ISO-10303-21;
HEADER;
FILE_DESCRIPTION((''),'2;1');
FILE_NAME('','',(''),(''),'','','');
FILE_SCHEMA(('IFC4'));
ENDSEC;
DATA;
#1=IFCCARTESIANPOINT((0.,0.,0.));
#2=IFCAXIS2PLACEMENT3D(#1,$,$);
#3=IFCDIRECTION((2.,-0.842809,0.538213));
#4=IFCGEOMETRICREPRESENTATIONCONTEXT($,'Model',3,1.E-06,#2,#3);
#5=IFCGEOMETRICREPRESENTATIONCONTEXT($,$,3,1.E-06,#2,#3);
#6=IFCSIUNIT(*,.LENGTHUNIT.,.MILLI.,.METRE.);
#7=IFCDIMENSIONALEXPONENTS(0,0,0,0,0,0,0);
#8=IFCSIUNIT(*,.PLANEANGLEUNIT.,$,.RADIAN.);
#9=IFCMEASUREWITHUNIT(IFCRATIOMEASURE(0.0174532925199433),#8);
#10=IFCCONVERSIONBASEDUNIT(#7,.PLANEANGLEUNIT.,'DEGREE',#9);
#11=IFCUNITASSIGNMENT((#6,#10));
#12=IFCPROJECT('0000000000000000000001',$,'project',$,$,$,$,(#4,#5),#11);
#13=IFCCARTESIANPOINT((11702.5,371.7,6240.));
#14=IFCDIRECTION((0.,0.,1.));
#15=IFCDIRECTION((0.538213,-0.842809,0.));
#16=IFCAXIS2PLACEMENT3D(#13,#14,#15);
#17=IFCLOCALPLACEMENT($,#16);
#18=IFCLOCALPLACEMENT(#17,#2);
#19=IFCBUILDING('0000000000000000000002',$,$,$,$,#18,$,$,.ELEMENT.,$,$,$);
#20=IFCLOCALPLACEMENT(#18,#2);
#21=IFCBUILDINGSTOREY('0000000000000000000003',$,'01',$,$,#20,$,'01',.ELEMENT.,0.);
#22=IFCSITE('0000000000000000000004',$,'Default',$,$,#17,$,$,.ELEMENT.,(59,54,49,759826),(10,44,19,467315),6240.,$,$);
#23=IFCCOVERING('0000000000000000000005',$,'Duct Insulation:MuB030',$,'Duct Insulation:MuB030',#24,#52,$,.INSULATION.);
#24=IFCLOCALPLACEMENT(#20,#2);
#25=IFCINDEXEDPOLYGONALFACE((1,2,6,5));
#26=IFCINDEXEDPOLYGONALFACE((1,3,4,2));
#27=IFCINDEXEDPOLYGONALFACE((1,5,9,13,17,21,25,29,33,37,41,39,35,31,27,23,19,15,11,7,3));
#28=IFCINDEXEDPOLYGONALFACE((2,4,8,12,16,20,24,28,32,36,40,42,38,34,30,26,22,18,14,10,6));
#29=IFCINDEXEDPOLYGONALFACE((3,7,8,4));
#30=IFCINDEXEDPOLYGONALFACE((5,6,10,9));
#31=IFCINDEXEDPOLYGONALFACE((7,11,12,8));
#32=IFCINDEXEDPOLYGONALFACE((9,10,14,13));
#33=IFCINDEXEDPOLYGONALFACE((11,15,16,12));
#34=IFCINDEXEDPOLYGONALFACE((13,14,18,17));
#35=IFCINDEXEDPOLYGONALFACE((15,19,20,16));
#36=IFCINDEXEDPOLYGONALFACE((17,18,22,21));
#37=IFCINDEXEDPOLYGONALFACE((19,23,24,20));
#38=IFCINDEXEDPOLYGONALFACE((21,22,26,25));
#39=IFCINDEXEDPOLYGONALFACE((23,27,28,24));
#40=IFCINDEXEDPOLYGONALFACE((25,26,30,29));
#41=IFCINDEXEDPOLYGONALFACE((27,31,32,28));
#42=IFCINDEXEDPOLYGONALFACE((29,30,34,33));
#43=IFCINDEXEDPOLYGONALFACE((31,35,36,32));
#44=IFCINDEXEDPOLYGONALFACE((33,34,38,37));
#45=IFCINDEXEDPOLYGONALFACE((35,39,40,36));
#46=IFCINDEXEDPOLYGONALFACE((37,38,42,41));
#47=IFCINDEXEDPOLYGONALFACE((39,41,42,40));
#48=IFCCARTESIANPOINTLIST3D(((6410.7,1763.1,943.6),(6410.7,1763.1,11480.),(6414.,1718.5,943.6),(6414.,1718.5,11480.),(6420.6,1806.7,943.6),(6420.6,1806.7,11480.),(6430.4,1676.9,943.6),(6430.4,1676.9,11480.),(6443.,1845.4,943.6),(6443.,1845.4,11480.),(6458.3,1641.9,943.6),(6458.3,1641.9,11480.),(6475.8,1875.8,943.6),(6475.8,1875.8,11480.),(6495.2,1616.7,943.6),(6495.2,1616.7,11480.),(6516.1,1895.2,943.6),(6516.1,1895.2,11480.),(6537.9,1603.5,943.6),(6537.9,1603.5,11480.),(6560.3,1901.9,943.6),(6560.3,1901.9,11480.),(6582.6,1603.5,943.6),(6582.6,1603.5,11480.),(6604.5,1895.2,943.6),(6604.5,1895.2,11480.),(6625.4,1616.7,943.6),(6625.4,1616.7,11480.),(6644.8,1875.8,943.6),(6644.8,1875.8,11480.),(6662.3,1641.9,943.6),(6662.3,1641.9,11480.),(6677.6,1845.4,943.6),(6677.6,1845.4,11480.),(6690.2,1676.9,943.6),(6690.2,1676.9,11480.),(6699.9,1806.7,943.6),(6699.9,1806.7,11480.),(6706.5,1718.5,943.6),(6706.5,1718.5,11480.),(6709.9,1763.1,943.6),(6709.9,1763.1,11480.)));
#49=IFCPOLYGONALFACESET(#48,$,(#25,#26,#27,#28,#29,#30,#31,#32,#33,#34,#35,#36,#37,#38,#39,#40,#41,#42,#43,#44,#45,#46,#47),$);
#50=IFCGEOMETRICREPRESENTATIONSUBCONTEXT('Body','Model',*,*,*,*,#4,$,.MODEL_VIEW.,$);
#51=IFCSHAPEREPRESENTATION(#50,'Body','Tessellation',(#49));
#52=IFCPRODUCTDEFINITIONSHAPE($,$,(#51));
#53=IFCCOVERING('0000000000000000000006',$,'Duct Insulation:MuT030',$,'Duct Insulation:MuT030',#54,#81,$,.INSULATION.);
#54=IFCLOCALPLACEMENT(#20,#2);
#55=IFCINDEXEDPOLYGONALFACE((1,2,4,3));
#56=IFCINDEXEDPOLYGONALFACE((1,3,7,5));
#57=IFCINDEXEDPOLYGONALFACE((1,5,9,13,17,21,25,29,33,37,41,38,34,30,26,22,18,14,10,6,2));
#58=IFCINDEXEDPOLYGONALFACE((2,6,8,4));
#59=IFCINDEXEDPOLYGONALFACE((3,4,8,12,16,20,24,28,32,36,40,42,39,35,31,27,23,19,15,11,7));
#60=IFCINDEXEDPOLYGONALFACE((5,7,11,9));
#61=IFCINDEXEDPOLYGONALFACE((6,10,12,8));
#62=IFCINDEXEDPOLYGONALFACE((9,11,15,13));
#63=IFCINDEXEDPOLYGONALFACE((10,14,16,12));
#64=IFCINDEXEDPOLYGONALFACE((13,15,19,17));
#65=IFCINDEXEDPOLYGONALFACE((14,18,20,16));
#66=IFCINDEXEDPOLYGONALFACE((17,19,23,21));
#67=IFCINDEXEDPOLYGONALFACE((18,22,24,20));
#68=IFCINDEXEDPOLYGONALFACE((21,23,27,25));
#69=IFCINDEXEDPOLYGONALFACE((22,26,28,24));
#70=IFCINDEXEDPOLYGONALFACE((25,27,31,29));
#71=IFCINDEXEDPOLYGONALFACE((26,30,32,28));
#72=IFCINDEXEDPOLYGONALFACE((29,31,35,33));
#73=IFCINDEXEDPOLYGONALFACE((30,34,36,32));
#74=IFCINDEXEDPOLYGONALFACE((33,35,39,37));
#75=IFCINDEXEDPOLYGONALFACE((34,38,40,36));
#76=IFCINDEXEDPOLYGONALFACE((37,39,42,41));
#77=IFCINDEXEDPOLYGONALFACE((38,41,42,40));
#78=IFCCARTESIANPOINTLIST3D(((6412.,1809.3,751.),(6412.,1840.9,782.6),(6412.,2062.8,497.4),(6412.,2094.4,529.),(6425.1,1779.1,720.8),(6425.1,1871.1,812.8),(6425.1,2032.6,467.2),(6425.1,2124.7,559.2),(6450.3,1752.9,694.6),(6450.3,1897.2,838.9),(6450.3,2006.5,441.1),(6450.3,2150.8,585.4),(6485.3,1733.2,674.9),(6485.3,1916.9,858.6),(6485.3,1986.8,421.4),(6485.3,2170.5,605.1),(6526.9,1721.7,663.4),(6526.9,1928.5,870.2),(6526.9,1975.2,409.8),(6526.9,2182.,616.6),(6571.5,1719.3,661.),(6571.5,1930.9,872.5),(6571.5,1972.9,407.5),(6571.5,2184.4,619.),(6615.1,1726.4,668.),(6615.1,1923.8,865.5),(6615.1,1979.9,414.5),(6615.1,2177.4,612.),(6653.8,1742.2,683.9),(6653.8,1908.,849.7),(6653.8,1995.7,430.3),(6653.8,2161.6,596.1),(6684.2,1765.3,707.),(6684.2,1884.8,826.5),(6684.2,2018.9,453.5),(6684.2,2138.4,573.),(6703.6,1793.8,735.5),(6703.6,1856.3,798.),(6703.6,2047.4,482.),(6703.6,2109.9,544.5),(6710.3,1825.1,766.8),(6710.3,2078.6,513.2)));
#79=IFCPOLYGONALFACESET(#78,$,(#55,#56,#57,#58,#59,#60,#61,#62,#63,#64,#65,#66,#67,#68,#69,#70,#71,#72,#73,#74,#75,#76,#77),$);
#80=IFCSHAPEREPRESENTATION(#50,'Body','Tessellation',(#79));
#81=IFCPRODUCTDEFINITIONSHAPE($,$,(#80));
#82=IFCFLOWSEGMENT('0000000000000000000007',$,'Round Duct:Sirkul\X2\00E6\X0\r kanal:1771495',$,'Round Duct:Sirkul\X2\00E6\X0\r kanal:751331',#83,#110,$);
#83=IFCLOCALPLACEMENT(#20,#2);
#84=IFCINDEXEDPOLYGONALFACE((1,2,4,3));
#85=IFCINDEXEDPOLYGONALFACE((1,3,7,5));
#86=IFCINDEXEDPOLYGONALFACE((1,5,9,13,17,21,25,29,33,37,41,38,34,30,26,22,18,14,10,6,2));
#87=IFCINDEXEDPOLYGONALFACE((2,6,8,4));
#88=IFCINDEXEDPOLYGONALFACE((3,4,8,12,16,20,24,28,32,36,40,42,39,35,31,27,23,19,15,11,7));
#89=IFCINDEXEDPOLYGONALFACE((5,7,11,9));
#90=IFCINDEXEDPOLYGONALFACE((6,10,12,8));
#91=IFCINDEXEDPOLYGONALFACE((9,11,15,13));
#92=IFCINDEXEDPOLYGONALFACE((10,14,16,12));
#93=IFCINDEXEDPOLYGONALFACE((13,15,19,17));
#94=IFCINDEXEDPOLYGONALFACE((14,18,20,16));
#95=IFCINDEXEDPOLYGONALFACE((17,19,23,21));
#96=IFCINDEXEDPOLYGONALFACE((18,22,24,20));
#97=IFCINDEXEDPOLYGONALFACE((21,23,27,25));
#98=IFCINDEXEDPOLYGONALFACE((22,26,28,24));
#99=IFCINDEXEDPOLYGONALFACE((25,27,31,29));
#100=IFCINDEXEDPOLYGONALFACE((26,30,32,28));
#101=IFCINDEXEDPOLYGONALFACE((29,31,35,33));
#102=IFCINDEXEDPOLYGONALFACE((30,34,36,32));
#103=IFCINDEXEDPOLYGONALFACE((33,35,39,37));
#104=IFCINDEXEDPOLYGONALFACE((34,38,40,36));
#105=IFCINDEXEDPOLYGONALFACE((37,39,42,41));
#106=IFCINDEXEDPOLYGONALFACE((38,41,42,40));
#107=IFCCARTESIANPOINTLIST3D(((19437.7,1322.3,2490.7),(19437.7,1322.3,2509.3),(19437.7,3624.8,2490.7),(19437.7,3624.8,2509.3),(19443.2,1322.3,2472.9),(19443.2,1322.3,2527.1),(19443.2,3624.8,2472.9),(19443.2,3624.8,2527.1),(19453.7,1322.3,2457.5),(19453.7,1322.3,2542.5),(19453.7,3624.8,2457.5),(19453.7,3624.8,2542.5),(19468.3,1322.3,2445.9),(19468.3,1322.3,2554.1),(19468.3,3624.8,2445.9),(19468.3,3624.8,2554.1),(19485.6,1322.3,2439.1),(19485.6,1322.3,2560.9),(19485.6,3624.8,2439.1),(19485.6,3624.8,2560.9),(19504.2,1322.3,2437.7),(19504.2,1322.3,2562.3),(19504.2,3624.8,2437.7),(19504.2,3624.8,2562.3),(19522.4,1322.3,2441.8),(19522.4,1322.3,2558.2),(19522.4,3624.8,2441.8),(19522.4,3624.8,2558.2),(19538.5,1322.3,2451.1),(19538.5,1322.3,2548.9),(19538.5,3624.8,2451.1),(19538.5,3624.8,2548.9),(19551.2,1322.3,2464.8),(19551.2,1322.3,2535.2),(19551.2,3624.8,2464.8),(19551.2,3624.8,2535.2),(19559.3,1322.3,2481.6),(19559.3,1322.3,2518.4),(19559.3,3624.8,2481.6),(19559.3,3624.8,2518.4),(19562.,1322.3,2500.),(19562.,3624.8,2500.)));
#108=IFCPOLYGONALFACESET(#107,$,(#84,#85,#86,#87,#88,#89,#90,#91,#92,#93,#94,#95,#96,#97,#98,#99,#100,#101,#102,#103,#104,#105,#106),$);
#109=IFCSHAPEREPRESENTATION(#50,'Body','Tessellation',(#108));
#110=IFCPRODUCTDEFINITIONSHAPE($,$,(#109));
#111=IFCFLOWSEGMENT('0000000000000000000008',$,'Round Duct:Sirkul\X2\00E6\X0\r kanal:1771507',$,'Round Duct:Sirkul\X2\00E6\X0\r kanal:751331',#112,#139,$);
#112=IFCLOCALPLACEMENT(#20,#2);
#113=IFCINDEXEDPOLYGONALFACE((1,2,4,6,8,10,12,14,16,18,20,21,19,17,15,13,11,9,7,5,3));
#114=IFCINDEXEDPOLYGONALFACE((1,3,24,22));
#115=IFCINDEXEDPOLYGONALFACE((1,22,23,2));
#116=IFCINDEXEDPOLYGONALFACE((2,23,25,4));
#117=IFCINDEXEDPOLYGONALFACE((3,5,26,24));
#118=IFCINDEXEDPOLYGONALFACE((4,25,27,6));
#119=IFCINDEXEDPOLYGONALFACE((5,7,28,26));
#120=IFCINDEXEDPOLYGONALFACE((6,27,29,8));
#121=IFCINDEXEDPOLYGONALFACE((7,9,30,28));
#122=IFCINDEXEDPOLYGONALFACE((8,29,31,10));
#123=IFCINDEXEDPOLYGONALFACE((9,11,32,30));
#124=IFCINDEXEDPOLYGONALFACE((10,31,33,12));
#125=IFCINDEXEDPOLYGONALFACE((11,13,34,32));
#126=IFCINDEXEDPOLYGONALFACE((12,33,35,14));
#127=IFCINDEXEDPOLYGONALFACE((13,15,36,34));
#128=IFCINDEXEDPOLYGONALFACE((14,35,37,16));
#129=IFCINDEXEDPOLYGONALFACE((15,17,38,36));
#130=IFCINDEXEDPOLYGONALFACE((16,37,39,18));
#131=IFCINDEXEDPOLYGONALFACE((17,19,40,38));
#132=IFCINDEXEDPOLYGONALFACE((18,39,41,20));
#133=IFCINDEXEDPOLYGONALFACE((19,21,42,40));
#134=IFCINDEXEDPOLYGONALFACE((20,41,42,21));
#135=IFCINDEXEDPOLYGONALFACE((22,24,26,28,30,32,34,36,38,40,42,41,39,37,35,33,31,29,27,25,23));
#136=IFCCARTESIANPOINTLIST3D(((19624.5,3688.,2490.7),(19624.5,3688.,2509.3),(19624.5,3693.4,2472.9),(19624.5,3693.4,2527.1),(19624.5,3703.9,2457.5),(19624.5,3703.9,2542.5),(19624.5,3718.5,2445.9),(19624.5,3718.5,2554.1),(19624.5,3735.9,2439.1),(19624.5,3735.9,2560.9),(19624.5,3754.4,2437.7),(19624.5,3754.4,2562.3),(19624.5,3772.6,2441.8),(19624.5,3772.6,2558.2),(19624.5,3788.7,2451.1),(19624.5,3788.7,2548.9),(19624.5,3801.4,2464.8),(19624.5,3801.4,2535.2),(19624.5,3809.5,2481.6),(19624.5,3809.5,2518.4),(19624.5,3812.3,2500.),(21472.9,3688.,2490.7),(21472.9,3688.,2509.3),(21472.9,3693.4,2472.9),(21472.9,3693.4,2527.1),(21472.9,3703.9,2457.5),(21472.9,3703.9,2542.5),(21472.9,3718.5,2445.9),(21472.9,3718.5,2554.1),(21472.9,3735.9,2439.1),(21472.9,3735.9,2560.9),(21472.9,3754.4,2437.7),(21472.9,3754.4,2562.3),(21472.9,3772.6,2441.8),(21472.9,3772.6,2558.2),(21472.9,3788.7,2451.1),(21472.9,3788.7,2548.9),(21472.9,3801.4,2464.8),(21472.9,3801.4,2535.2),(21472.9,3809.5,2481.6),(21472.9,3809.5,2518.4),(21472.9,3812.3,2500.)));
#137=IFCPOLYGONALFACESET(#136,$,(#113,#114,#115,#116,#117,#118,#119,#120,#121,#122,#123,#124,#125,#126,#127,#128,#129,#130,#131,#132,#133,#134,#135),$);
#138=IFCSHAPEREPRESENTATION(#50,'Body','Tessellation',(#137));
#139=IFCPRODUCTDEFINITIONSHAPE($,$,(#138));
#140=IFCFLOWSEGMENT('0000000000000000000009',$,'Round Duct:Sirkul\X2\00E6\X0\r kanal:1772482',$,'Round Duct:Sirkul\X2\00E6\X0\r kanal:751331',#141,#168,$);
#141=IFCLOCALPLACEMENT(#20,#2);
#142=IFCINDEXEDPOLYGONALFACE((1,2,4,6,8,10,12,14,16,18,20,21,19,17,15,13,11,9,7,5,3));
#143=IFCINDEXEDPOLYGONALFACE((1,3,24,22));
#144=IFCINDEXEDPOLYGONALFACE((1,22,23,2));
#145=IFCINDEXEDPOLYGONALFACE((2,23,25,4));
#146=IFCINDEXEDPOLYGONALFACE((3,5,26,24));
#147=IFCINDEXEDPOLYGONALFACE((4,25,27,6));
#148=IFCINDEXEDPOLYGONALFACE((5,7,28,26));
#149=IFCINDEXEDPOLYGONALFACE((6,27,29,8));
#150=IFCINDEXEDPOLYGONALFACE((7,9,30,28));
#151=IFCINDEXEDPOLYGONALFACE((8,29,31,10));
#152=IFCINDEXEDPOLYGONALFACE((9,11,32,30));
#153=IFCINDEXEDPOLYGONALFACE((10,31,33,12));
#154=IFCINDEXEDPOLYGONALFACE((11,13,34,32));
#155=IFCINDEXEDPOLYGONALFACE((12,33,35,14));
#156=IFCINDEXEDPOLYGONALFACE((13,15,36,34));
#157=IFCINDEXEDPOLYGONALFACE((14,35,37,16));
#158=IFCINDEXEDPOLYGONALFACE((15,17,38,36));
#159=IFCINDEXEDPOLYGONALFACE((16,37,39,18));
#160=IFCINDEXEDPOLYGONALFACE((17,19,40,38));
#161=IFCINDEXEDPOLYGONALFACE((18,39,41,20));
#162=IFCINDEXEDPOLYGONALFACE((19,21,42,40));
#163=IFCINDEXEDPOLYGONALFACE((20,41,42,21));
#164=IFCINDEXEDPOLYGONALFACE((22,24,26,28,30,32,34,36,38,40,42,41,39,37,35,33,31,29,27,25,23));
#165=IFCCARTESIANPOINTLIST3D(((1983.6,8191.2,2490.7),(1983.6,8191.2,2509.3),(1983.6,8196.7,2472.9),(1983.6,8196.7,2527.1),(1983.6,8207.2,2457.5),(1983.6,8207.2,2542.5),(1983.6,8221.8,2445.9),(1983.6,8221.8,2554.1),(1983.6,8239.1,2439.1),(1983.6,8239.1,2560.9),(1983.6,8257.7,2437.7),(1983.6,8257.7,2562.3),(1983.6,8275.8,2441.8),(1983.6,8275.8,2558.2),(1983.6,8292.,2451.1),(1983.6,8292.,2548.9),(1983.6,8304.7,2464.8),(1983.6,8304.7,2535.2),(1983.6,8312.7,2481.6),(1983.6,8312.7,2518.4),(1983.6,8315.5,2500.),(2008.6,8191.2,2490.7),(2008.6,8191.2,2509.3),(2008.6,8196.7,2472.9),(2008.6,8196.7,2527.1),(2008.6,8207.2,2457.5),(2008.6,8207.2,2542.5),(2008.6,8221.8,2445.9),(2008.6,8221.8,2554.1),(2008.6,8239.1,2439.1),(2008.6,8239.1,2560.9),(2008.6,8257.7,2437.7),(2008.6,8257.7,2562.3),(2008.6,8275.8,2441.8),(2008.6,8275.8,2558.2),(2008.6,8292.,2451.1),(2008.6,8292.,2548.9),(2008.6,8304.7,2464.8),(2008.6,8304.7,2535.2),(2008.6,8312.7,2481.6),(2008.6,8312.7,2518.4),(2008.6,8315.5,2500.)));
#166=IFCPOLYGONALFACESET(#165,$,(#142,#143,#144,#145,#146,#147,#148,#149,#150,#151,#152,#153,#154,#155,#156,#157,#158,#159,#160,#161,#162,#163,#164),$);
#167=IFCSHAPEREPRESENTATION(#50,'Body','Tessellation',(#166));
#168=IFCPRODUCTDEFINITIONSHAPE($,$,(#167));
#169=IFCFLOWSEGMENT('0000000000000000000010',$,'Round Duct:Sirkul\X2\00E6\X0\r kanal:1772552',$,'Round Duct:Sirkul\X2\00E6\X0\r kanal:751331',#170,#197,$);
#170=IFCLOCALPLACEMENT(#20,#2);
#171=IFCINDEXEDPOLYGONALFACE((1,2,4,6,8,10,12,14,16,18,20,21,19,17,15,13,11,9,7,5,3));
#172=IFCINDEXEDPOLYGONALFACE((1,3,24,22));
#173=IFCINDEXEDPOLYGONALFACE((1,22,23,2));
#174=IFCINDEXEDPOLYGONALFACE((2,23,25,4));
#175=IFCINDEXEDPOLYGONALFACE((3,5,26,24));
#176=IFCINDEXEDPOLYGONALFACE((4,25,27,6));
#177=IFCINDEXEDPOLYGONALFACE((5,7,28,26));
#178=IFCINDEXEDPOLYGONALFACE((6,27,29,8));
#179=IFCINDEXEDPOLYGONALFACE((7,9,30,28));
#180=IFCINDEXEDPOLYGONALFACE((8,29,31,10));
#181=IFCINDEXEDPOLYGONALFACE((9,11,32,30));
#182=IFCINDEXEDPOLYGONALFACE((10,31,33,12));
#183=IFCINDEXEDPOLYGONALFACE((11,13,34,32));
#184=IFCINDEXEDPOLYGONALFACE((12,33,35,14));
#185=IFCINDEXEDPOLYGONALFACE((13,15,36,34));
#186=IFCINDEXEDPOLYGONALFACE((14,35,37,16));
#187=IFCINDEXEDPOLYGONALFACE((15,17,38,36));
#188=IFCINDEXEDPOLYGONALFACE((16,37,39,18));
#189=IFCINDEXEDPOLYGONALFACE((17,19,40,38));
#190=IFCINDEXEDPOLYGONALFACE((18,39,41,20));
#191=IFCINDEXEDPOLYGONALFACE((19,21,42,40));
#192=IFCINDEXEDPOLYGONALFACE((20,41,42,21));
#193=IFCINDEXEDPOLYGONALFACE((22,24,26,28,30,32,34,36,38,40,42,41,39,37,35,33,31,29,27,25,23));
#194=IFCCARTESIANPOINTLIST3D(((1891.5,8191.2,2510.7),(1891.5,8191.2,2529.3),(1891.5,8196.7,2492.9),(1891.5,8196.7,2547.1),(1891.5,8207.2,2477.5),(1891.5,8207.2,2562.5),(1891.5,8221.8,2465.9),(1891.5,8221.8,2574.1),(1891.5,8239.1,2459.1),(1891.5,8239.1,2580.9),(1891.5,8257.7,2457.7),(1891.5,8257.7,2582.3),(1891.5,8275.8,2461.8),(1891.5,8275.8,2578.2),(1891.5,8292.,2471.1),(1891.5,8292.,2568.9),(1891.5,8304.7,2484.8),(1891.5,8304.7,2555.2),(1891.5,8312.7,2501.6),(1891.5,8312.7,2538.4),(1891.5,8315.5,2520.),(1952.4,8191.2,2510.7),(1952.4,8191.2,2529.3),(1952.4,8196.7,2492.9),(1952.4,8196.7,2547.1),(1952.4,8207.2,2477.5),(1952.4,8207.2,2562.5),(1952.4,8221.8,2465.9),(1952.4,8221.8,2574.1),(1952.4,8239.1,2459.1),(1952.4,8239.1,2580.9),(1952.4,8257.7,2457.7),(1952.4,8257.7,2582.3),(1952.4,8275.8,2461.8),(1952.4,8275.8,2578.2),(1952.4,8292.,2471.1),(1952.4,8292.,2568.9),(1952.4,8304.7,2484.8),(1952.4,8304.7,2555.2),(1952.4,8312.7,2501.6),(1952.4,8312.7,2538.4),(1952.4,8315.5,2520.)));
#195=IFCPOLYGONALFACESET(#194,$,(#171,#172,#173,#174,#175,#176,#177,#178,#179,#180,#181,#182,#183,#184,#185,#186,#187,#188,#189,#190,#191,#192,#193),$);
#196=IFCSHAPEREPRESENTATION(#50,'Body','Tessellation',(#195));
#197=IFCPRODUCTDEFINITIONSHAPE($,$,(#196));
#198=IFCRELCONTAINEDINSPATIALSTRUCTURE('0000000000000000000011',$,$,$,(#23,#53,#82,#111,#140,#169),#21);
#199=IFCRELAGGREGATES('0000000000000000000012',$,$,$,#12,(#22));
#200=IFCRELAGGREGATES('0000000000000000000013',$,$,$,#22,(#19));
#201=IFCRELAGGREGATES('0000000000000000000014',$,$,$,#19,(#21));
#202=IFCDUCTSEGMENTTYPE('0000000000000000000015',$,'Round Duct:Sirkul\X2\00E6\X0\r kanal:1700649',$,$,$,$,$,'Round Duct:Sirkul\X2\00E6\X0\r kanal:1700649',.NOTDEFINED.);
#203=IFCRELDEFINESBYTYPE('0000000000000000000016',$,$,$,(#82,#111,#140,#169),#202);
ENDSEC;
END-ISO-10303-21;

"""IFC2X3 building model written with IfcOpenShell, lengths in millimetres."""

from ifc_helpers import new_model, entity, si_unit, converted_unit, direction, frame, frame_2d, origin, origin_2d_with_axis, place, context, subcontext, project, spatial, circle, extrude, type_object, element, save


model = new_model("IFC2X3")

# Units and contexts
model_context = context("Model", 3, precision=1e-06, world=origin(), true_north=direction((2.0, -0.842809, 0.538213)))
context_of_model = context(None, 3, precision=1e-06, world=origin(), true_north=direction((2.0, -0.842809, 0.538213)))
body_context = subcontext(model_context, "Body", "Model", "MODEL_VIEW")
ifc_project = project(units=[si_unit("LENGTHUNIT", "METRE", prefix="MILLI"), converted_unit("PLANEANGLEUNIT", "DEGREE", entity("IfcRatioMeasure", 0.0174532925199433), si_unit("PLANEANGLEUNIT", "RADIAN"), dimensions=[0, 0, 0, 0, 0, 0, 0])], contexts=[model_context, context_of_model])

# Site, building, storey
site_placement = place(None, frame((11702.5, 371.7, 6240.0), z_axis=(0.0, 0.0, 1.0), x_axis=(0.538213, -0.842809, 0.0)))
site = spatial("IfcSite", under=ifc_project, at=site_placement, Name="Default", CompositionType="ELEMENT", RefLatitude=(59, 54, 49, 759826), RefLongitude=(10, 44, 19, 467315), RefElevation=6240.0)
building_placement = place(site_placement, origin())
building = spatial("IfcBuilding", under=site, at=building_placement, CompositionType="ELEMENT")
storey_placement = place(building_placement, origin())
storey = spatial("IfcBuildingStorey", under=building, at=storey_placement, Name="01", LongName="01", CompositionType="ELEMENT", Elevation=0.0)

# Coverings
covering_1_placement = place(storey_placement, origin())
element("IfcCovering", 1, at=covering_1_placement, inside=storey, Name="Duct Insulation:MuB030", ObjectType="Duct Insulation:MuB030", PredefinedType="INSULATION", context=body_context, shape_type="SweptSolid", body=[
    extrude(circle(Radius=150.0, at=frame_2d((0.0, 0.0), x_axis=(1.0, 0.0))), frame((6560.3, 1751.9, 943.6), z_axis=(0.0, 0.0, 1.0), x_axis=(0.0, 1.0, 0.0)), (0.0, 0.0, 1.0), 10536.4),
])
covering_2_placement = place(storey_placement, origin())
element("IfcCovering", 2, at=covering_2_placement, inside=storey, Name="Duct Insulation:MuT030", ObjectType="Duct Insulation:MuT030", PredefinedType="INSULATION", context=body_context, shape_type="SweptSolid", body=[
    extrude(circle(Radius=150.0, at=frame_2d((0.0, 0.0), x_axis=(1.0, 0.0))), frame((6560.3, 1825.1, 766.8), z_axis=(0.0, 0.707107, -0.707107), x_axis=(1.0, 0.0, 0.0)), (0.0, 0.0, 1.0), 358.6),
])

# Flow segments
duct_segment_type = type_object("IfcDuctSegmentType", Name="Round Duct:Sirkulær kanal:1700649", ElementType="Round Duct:Sirkulær kanal:1700649", PredefinedType="NOTDEFINED")
flow_segment_1_placement = place(storey_placement, origin())
element("IfcFlowSegment", 3, at=flow_segment_1_placement, inside=storey, type_object=duct_segment_type, Name="Round Duct:Sirkulær kanal:1771495", ObjectType="Round Duct:Sirkulær kanal:751331", context=body_context, shape_type="SweptSolid", body=[
    extrude(circle(Radius=62.5, at=origin_2d_with_axis()), frame((19499.5, 1322.3, 2500.0), z_axis=(0.0, 1.0, 0.0), x_axis=(1.0, 0.0, 0.0)), (0.0, 0.0, 1.0), 2302.5),
])
flow_segment_2_placement = place(storey_placement, origin())
element("IfcFlowSegment", 4, at=flow_segment_2_placement, inside=storey, type_object=duct_segment_type, Name="Round Duct:Sirkulær kanal:1771507", ObjectType="Round Duct:Sirkulær kanal:751331", context=body_context, shape_type="SweptSolid", body=[
    extrude(circle(Radius=62.5, at=origin_2d_with_axis()), frame((19624.5, 3749.8, 2500.0), z_axis=(1.0, 0.0, 0.0), x_axis=(0.0, 1.0, 0.0)), (0.0, 0.0, 1.0), 1848.4),
])
flow_segment_3_placement = place(storey_placement, origin())
element("IfcFlowSegment", 5, at=flow_segment_3_placement, inside=storey, type_object=duct_segment_type, Name="Round Duct:Sirkulær kanal:1772482", ObjectType="Round Duct:Sirkulær kanal:751331", context=body_context, shape_type="SweptSolid", body=[
    extrude(circle(Radius=62.5, at=origin_2d_with_axis()), frame((1983.6, 8253.0, 2500.0), z_axis=(1.0, 0.0, 0.0), x_axis=(0.0, 1.0, 0.0)), (0.0, 0.0, 1.0), 25.0),
])
flow_segment_4_placement = place(storey_placement, origin())
element("IfcFlowSegment", 6, at=flow_segment_4_placement, inside=storey, type_object=duct_segment_type, Name="Round Duct:Sirkulær kanal:1772552", ObjectType="Round Duct:Sirkulær kanal:751331", context=body_context, shape_type="SweptSolid", body=[
    extrude(circle(Radius=62.5, at=origin_2d_with_axis()), frame((1891.5, 8253.0, 2520.0), z_axis=(1.0, 0.0, 0.0), x_axis=(0.0, 1.0, 0.0)), (0.0, 0.0, 1.0), 60.8),
])

save(model, "model.ifc")
